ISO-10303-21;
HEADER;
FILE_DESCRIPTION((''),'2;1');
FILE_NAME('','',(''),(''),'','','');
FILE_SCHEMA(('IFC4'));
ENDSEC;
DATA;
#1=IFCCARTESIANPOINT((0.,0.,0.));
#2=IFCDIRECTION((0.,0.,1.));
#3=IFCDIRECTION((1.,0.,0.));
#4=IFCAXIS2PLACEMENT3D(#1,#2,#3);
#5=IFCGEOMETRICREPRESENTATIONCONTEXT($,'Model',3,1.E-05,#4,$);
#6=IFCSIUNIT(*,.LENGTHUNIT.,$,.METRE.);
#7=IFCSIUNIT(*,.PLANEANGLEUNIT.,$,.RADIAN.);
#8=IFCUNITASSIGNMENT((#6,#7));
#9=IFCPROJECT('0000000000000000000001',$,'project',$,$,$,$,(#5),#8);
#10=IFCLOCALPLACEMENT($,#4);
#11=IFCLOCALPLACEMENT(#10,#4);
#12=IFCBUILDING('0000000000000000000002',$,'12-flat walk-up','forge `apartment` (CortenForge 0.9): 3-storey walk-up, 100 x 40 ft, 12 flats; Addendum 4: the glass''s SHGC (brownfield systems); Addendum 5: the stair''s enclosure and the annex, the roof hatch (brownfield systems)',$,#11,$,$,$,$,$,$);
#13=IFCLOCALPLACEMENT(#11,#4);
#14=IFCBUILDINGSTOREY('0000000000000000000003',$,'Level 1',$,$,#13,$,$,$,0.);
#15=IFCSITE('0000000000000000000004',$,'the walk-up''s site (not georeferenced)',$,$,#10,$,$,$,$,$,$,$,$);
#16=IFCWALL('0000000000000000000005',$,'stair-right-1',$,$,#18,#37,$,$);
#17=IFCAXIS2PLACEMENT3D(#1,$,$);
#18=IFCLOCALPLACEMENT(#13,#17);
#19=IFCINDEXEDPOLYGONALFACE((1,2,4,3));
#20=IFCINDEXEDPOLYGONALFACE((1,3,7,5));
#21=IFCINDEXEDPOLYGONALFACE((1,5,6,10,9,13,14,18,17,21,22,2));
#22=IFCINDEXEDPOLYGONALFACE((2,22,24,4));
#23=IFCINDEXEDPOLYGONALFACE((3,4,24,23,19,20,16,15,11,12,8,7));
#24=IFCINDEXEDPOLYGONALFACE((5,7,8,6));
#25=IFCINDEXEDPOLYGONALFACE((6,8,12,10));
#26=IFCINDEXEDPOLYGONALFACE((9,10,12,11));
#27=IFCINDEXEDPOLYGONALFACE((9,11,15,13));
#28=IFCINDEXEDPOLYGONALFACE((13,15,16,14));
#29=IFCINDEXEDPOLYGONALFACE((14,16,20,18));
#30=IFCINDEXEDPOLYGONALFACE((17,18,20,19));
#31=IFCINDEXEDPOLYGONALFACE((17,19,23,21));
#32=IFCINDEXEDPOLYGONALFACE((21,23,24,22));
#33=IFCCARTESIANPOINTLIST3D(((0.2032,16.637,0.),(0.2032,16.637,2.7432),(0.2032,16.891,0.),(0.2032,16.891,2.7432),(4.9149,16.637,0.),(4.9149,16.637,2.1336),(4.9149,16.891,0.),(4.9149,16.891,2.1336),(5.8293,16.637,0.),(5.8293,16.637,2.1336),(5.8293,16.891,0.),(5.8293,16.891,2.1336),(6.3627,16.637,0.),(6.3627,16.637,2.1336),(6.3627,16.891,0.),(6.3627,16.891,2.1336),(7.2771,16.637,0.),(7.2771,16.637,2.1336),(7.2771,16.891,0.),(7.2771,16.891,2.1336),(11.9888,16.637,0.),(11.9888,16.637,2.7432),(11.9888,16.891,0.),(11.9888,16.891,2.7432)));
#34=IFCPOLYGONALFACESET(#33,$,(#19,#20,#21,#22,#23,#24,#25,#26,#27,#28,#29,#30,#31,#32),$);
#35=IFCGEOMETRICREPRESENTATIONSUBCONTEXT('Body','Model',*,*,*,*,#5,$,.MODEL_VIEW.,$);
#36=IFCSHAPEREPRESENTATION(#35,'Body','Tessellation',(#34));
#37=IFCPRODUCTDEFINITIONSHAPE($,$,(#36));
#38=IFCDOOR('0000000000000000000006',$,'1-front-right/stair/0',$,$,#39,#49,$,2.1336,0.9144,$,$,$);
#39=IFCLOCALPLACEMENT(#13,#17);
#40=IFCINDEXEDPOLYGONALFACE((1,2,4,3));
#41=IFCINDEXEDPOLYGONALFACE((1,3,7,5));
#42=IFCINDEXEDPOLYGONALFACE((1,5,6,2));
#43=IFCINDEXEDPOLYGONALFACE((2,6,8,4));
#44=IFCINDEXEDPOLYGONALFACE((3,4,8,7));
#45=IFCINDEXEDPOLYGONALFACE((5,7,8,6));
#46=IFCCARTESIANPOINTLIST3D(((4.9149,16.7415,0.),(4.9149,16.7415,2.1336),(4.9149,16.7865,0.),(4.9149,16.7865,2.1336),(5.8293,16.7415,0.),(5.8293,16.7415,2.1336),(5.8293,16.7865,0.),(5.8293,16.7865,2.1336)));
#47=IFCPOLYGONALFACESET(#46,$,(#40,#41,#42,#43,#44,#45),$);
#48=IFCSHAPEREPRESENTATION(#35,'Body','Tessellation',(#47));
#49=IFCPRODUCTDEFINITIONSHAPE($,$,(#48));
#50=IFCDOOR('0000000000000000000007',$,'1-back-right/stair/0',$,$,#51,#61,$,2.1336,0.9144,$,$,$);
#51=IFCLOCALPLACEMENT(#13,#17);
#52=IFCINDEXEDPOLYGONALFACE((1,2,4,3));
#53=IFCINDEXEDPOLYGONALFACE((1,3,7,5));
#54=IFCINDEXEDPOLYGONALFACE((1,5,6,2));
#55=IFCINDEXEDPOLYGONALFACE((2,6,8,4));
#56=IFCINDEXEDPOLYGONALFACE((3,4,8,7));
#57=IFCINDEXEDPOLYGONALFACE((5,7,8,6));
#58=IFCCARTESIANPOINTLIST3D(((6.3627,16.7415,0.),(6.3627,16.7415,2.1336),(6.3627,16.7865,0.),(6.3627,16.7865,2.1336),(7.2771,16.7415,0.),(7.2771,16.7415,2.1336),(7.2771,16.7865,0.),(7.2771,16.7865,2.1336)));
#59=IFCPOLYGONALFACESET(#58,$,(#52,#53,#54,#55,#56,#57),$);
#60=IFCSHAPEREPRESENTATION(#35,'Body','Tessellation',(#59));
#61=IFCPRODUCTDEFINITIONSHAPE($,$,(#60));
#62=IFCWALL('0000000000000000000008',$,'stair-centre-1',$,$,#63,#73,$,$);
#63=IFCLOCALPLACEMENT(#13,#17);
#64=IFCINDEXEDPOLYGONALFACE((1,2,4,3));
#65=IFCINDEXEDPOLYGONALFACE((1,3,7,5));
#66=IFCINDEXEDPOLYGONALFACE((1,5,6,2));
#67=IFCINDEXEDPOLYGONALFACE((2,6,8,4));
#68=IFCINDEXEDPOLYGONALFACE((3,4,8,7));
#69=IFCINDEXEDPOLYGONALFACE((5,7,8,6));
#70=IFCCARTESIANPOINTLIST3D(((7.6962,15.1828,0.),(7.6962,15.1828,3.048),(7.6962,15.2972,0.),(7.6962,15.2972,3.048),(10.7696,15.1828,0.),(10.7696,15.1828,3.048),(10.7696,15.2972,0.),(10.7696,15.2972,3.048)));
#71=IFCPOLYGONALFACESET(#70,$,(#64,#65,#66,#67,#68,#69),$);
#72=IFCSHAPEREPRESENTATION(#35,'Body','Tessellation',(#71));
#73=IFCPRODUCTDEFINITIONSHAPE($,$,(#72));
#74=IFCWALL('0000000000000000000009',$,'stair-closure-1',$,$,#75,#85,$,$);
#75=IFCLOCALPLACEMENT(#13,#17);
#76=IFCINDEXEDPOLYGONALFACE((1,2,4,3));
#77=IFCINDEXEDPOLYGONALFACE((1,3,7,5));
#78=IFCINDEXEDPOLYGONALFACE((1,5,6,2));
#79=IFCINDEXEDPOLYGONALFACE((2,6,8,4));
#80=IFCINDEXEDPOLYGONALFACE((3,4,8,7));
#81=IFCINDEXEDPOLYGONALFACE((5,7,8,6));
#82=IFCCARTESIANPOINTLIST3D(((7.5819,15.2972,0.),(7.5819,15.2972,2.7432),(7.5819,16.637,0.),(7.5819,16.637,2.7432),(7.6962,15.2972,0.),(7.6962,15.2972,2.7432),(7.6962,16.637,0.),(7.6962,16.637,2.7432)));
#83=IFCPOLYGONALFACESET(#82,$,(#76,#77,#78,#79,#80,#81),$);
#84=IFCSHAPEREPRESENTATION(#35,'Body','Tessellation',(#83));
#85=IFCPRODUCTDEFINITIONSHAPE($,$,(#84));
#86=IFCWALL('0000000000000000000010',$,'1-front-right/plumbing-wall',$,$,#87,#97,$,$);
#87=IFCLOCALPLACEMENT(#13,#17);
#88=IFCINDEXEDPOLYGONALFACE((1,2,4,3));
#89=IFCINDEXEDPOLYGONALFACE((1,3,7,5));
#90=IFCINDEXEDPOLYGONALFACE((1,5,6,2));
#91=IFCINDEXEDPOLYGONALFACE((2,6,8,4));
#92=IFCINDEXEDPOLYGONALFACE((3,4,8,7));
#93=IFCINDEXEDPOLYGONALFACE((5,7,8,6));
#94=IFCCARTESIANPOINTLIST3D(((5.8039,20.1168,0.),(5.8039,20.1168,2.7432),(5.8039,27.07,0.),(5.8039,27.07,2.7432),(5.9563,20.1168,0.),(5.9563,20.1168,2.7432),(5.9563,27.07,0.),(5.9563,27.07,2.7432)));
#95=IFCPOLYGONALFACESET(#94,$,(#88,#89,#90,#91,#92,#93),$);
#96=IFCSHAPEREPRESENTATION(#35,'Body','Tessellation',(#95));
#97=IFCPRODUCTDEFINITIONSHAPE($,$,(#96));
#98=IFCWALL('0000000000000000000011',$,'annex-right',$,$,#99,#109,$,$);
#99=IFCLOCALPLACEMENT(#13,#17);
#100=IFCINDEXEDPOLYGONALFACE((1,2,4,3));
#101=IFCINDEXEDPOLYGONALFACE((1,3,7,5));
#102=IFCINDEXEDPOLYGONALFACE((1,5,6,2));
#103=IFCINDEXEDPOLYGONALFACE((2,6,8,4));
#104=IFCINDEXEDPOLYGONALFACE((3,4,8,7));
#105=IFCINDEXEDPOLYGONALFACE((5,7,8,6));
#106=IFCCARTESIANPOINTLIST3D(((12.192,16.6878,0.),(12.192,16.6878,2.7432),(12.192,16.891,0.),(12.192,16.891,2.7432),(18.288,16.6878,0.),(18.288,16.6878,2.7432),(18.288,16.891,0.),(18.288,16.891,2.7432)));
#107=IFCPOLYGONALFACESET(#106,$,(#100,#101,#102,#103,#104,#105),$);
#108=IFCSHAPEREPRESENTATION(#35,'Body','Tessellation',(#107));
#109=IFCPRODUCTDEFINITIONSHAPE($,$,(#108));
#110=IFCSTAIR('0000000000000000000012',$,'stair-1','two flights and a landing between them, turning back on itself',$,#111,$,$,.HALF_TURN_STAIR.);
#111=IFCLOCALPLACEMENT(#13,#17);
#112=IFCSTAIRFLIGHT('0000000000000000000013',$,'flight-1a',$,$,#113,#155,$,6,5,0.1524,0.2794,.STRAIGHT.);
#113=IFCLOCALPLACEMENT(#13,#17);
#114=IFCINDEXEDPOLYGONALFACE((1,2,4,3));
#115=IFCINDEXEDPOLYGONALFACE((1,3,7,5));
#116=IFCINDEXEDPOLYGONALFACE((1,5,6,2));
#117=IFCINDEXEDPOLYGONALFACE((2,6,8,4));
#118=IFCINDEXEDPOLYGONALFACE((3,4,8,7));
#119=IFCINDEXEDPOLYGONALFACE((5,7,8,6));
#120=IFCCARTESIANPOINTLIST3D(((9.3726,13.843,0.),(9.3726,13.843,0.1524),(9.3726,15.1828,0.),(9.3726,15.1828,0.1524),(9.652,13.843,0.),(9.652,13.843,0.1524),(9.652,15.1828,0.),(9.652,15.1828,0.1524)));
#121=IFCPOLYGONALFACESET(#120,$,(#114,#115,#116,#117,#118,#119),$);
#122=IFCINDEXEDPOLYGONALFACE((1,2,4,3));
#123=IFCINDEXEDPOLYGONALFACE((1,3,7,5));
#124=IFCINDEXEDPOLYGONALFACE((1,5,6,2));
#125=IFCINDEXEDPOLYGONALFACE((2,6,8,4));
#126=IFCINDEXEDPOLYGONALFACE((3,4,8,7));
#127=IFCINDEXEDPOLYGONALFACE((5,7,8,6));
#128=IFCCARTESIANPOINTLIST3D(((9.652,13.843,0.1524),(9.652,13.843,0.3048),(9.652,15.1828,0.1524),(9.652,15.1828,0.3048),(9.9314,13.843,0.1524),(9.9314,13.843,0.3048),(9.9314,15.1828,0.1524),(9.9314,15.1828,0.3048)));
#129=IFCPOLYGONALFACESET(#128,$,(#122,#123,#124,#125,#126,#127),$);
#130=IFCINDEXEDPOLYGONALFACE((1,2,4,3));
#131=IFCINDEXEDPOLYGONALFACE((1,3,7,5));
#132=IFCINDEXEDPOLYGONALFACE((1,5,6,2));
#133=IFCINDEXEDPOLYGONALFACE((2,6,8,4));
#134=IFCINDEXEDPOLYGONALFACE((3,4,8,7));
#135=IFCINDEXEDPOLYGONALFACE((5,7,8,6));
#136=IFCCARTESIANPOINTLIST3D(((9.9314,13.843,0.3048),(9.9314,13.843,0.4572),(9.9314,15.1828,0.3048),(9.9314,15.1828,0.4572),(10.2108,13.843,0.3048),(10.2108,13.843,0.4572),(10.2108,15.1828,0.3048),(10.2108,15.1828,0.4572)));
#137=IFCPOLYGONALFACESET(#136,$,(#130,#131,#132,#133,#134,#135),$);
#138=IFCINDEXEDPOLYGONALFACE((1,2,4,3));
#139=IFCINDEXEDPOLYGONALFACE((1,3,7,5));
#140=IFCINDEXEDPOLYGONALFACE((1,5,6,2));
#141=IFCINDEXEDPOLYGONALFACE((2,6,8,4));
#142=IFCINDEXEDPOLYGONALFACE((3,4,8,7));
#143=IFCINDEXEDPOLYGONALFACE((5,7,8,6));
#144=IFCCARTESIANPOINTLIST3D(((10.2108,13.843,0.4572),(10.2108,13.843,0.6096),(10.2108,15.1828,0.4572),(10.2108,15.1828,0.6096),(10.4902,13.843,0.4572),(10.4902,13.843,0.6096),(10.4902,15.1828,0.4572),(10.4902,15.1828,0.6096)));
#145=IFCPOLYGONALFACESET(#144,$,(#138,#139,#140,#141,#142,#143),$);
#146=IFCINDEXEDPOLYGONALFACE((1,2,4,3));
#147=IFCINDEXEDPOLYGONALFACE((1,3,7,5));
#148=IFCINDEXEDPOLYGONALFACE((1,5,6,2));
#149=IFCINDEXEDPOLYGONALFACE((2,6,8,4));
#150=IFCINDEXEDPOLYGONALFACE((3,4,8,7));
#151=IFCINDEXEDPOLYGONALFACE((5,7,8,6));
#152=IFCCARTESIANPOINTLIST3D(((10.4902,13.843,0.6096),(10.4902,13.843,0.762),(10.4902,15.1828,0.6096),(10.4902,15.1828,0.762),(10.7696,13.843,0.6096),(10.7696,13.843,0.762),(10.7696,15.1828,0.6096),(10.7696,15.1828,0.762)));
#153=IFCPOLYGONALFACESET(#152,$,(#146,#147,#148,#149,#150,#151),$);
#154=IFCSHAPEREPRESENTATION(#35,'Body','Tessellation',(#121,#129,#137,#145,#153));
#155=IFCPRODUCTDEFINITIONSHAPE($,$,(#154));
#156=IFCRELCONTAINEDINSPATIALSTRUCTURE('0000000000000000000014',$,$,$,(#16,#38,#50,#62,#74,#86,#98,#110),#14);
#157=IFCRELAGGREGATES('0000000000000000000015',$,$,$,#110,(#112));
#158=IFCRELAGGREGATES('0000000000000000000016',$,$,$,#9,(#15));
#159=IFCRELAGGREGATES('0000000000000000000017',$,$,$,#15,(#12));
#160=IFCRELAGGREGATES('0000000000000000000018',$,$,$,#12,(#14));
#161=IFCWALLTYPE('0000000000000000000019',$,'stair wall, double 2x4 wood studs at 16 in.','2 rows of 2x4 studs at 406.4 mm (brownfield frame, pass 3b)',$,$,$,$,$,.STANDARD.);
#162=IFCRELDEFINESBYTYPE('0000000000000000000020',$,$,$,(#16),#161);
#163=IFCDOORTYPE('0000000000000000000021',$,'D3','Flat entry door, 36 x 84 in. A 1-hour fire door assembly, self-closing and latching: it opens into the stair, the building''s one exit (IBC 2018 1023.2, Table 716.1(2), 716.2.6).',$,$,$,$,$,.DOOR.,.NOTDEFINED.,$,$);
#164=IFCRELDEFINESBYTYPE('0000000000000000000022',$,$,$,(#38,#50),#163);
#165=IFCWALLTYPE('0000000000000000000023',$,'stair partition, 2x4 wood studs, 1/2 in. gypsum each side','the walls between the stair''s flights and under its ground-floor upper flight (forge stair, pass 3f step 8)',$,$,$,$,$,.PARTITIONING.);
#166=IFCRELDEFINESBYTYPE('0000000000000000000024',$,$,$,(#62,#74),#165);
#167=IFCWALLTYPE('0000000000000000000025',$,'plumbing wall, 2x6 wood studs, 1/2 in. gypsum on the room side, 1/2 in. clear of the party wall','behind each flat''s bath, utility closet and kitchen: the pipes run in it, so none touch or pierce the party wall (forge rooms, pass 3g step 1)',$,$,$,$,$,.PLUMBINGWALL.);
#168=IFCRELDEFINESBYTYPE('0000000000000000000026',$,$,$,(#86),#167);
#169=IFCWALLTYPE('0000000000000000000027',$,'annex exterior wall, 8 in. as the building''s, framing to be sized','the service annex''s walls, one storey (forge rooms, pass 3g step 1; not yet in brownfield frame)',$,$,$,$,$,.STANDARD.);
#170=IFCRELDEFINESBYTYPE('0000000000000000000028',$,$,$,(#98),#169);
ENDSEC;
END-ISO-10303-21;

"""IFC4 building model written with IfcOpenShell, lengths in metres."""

from ifc_helpers import new_model, si_unit, frame, frame_2d, origin, origin_with_axes, place, context, subcontext, project, spatial, rectangle, extrude, type_object, element, fill, aggregate, save


model = new_model("IFC4")

# Units and contexts
model_context = context("Model", 3, precision=1e-05, world=origin_with_axes())
body_context = subcontext(model_context, "Body", "Model", "MODEL_VIEW")
ifc_project = project(units=[si_unit("LENGTHUNIT", "METRE"), si_unit("PLANEANGLEUNIT", "RADIAN")], contexts=[model_context])

# Site, building, storey
site_placement = place(None, origin_with_axes())
site = spatial("IfcSite", under=ifc_project, at=site_placement, Name="the walk-up's site (not georeferenced)")
building_placement = place(site_placement, origin_with_axes())
building = spatial("IfcBuilding", under=site, at=building_placement, Name="12-flat walk-up", Description="forge `apartment` (CortenForge 0.9): 3-storey walk-up, 100 x 40 ft, 12 flats; Addendum 4: the glass's SHGC (brownfield systems); Addendum 5: the stair's enclosure and the annex, the roof hatch (brownfield systems)")
storey_placement = place(building_placement, origin_with_axes())
storey = spatial("IfcBuildingStorey", under=building, at=storey_placement, Name="Level 1", Elevation=0.0)

# Wall, openings, doors
wall_type_1 = type_object("IfcWallType", Name="stair wall, double 2x4 wood studs at 16 in.", Description="2 rows of 2x4 studs at 406.4 mm (brownfield frame, pass 3b)", PredefinedType="STANDARD")
wall_1_placement = place(storey_placement, frame((0.2032, 16.637, 0.0), z_axis=(0.0, 0.0, 1.0), x_axis=(1.0, 0.0, 0.0)))
wall_1 = element("IfcWall", 1, at=wall_1_placement, inside=storey, type_object=wall_type_1, Name="stair-right-1", context=body_context, shape_type="SweptSolid", body=[
    extrude(rectangle(XDim=11.7856, YDim=0.254, at=frame_2d((5.8928, 0.127))), origin(), (0.0, 0.0, 1.0), 2.7432),
])
opening_1_placement = place(wall_1_placement, frame((5.6261, 0.254, 0.0), z_axis=(0.0, 0.0, 1.0), x_axis=(-1.0, 0.0, 0.0)))
opening_1 = element("IfcOpeningElement", 2, at=opening_1_placement, cuts=wall_1, PredefinedType="OPENING", context=body_context, shape_type="SweptSolid", body=[
    extrude(rectangle(XDim=0.9144, YDim=0.254, at=frame_2d((0.4572, 0.127))), origin(), (0.0, 0.0, 1.0), 2.1336),
])
opening_2_placement = place(wall_1_placement, frame((7.0739, 0.254, 0.0), z_axis=(0.0, 0.0, 1.0), x_axis=(-1.0, 0.0, 0.0)))
opening_2 = element("IfcOpeningElement", 3, at=opening_2_placement, cuts=wall_1, PredefinedType="OPENING", context=body_context, shape_type="SweptSolid", body=[
    extrude(rectangle(XDim=0.9144, YDim=0.254, at=frame_2d((0.4572, 0.127))), origin(), (0.0, 0.0, 1.0), 2.1336),
])
door_type_1 = type_object("IfcDoorType", Name="D3", Description="Flat entry door, 36 x 84 in. A 1-hour fire door assembly, self-closing and latching: it opens into the stair, the building's one exit (IBC 2018 1023.2, Table 716.1(2), 716.2.6).", OperationType="NOTDEFINED", PredefinedType="DOOR")
door_1_placement = place(opening_1_placement, frame((0.0, 0.1045, 0.0), z_axis=(0.0, 0.0, 1.0), x_axis=(1.0, 0.0, 0.0)))
door_1 = element("IfcDoor", 4, at=door_1_placement, inside=storey, type_object=door_type_1, Name="1-front-right/stair/0", OverallHeight=2.1336, OverallWidth=0.9144, context=body_context, shape_type="SweptSolid", body=[
    extrude(rectangle(XDim=0.9144, YDim=0.045, at=frame_2d((0.4572, 0.0225))), origin(), (0.0, 0.0, 1.0), 2.1336),
])
fill(opening_1, door_1)
door_2_placement = place(opening_2_placement, frame((0.0, 0.1045, 0.0), z_axis=(0.0, 0.0, 1.0), x_axis=(1.0, 0.0, 0.0)))
door_2 = element("IfcDoor", 5, at=door_2_placement, inside=storey, type_object=door_type_1, Name="1-back-right/stair/0", OverallHeight=2.1336, OverallWidth=0.9144, context=body_context, shape_type="SweptSolid", body=[
    extrude(rectangle(XDim=0.9144, YDim=0.045, at=frame_2d((0.4572, 0.0225))), origin(), (0.0, 0.0, 1.0), 2.1336),
])
fill(opening_2, door_2)

# Walls
wall_type_2 = type_object("IfcWallType", Name="stair partition, 2x4 wood studs, 1/2 in. gypsum each side", Description="the walls between the stair's flights and under its ground-floor upper flight (forge stair, pass 3f step 8)", PredefinedType="PARTITIONING")
wall_2_placement = place(storey_placement, frame((7.6962, 15.1829, 0.0), z_axis=(0.0, 0.0, 1.0), x_axis=(1.0, 0.0, 0.0)))
element("IfcWall", 6, at=wall_2_placement, inside=storey, type_object=wall_type_2, Name="stair-centre-1", context=body_context, shape_type="SweptSolid", body=[
    extrude(rectangle(XDim=3.0734, YDim=0.1143, at=frame_2d((1.5367, 0.0572))), origin(), (0.0, 0.0, 1.0), 3.048),
])
wall_3_placement = place(storey_placement, frame((7.5819, 15.2972, 0.0), z_axis=(0.0, 0.0, 1.0), x_axis=(1.0, 0.0, 0.0)))
element("IfcWall", 7, at=wall_3_placement, inside=storey, type_object=wall_type_2, Name="stair-closure-1", context=body_context, shape_type="SweptSolid", body=[
    extrude(rectangle(XDim=0.1143, YDim=1.3399, at=frame_2d((0.0572, 0.6699))), origin(), (0.0, 0.0, 1.0), 2.7432),
])
wall_type_3 = type_object("IfcWallType", Name="plumbing wall, 2x6 wood studs, 1/2 in. gypsum on the room side, 1/2 in. clear of the party wall", Description="behind each flat's bath, utility closet and kitchen: the pipes run in it, so none touch or pierce the party wall (forge rooms, pass 3g step 1)", PredefinedType="PLUMBINGWALL")
wall_4_placement = place(storey_placement, frame((5.8039, 20.1168, 0.0), z_axis=(0.0, 0.0, 1.0), x_axis=(1.0, 0.0, 0.0)))
element("IfcWall", 8, at=wall_4_placement, inside=storey, type_object=wall_type_3, Name="1-front-right/plumbing-wall", context=body_context, shape_type="SweptSolid", body=[
    extrude(rectangle(XDim=0.1524, YDim=6.9532, at=frame_2d((0.0762, 3.4766))), origin(), (0.0, 0.0, 1.0), 2.7432),
])
wall_type_4 = type_object("IfcWallType", Name="annex exterior wall, 8 in. as the building's, framing to be sized", Description="the service annex's walls, one storey (forge rooms, pass 3g step 1; not yet in brownfield frame)", PredefinedType="STANDARD")
wall_5_placement = place(storey_placement, frame((12.192, 16.6878, 0.0), z_axis=(0.0, 0.0, 1.0), x_axis=(1.0, 0.0, 0.0)))
element("IfcWall", 9, at=wall_5_placement, inside=storey, type_object=wall_type_4, Name="annex-right", context=body_context, shape_type="SweptSolid", body=[
    extrude(rectangle(XDim=6.096, YDim=0.2032, at=frame_2d((3.048, 0.1016))), origin(), (0.0, 0.0, 1.0), 2.7432),
])

# Stair, stair flight
stair_placement = place(storey_placement, origin_with_axes())
stair = element("IfcStair", 10, at=stair_placement, inside=storey, Name="stair-1", Description="two flights and a landing between them, turning back on itself", PredefinedType="HALF_TURN_STAIR")
stair_flight_1_placement = place(stair_placement, frame((9.3726, 13.843, 0.0), z_axis=(0.0, 0.0, 1.0), x_axis=(1.0, 0.0, 0.0)))
stair_flight_1 = element("IfcStairFlight", 11, at=stair_flight_1_placement, Name="flight-1a", NumberOfRisers=6, NumberOfTreads=5, PredefinedType="STRAIGHT", RiserHeight=0.1524, TreadLength=0.2794, context=body_context, shape_type="SweptSolid", body=[
    extrude(rectangle(XDim=0.2794, YDim=1.3399, at=frame_2d((0.1397, 0.6699))), origin(), (0.0, 0.0, 1.0), 0.1524),
    extrude(rectangle(XDim=0.2794, YDim=1.3399, at=frame_2d((0.1397, 0.6699))), frame((0.2794, 0.0, 0.1524)), (0.0, 0.0, 1.0), 0.1524),
    extrude(rectangle(XDim=0.2794, YDim=1.3399, at=frame_2d((0.1397, 0.6699))), frame((0.5588, 0.0, 0.3048)), (0.0, 0.0, 1.0), 0.1524),
    extrude(rectangle(XDim=0.2794, YDim=1.3399, at=frame_2d((0.1397, 0.6699))), frame((0.8382, 0.0, 0.4572)), (0.0, 0.0, 1.0), 0.1524),
    extrude(rectangle(XDim=0.2794, YDim=1.3399, at=frame_2d((0.1397, 0.6699))), frame((1.1176, 0.0, 0.6096)), (0.0, 0.0, 1.0), 0.1524),
])
aggregate(stair, [stair_flight_1])

save(model, "model.ifc")
